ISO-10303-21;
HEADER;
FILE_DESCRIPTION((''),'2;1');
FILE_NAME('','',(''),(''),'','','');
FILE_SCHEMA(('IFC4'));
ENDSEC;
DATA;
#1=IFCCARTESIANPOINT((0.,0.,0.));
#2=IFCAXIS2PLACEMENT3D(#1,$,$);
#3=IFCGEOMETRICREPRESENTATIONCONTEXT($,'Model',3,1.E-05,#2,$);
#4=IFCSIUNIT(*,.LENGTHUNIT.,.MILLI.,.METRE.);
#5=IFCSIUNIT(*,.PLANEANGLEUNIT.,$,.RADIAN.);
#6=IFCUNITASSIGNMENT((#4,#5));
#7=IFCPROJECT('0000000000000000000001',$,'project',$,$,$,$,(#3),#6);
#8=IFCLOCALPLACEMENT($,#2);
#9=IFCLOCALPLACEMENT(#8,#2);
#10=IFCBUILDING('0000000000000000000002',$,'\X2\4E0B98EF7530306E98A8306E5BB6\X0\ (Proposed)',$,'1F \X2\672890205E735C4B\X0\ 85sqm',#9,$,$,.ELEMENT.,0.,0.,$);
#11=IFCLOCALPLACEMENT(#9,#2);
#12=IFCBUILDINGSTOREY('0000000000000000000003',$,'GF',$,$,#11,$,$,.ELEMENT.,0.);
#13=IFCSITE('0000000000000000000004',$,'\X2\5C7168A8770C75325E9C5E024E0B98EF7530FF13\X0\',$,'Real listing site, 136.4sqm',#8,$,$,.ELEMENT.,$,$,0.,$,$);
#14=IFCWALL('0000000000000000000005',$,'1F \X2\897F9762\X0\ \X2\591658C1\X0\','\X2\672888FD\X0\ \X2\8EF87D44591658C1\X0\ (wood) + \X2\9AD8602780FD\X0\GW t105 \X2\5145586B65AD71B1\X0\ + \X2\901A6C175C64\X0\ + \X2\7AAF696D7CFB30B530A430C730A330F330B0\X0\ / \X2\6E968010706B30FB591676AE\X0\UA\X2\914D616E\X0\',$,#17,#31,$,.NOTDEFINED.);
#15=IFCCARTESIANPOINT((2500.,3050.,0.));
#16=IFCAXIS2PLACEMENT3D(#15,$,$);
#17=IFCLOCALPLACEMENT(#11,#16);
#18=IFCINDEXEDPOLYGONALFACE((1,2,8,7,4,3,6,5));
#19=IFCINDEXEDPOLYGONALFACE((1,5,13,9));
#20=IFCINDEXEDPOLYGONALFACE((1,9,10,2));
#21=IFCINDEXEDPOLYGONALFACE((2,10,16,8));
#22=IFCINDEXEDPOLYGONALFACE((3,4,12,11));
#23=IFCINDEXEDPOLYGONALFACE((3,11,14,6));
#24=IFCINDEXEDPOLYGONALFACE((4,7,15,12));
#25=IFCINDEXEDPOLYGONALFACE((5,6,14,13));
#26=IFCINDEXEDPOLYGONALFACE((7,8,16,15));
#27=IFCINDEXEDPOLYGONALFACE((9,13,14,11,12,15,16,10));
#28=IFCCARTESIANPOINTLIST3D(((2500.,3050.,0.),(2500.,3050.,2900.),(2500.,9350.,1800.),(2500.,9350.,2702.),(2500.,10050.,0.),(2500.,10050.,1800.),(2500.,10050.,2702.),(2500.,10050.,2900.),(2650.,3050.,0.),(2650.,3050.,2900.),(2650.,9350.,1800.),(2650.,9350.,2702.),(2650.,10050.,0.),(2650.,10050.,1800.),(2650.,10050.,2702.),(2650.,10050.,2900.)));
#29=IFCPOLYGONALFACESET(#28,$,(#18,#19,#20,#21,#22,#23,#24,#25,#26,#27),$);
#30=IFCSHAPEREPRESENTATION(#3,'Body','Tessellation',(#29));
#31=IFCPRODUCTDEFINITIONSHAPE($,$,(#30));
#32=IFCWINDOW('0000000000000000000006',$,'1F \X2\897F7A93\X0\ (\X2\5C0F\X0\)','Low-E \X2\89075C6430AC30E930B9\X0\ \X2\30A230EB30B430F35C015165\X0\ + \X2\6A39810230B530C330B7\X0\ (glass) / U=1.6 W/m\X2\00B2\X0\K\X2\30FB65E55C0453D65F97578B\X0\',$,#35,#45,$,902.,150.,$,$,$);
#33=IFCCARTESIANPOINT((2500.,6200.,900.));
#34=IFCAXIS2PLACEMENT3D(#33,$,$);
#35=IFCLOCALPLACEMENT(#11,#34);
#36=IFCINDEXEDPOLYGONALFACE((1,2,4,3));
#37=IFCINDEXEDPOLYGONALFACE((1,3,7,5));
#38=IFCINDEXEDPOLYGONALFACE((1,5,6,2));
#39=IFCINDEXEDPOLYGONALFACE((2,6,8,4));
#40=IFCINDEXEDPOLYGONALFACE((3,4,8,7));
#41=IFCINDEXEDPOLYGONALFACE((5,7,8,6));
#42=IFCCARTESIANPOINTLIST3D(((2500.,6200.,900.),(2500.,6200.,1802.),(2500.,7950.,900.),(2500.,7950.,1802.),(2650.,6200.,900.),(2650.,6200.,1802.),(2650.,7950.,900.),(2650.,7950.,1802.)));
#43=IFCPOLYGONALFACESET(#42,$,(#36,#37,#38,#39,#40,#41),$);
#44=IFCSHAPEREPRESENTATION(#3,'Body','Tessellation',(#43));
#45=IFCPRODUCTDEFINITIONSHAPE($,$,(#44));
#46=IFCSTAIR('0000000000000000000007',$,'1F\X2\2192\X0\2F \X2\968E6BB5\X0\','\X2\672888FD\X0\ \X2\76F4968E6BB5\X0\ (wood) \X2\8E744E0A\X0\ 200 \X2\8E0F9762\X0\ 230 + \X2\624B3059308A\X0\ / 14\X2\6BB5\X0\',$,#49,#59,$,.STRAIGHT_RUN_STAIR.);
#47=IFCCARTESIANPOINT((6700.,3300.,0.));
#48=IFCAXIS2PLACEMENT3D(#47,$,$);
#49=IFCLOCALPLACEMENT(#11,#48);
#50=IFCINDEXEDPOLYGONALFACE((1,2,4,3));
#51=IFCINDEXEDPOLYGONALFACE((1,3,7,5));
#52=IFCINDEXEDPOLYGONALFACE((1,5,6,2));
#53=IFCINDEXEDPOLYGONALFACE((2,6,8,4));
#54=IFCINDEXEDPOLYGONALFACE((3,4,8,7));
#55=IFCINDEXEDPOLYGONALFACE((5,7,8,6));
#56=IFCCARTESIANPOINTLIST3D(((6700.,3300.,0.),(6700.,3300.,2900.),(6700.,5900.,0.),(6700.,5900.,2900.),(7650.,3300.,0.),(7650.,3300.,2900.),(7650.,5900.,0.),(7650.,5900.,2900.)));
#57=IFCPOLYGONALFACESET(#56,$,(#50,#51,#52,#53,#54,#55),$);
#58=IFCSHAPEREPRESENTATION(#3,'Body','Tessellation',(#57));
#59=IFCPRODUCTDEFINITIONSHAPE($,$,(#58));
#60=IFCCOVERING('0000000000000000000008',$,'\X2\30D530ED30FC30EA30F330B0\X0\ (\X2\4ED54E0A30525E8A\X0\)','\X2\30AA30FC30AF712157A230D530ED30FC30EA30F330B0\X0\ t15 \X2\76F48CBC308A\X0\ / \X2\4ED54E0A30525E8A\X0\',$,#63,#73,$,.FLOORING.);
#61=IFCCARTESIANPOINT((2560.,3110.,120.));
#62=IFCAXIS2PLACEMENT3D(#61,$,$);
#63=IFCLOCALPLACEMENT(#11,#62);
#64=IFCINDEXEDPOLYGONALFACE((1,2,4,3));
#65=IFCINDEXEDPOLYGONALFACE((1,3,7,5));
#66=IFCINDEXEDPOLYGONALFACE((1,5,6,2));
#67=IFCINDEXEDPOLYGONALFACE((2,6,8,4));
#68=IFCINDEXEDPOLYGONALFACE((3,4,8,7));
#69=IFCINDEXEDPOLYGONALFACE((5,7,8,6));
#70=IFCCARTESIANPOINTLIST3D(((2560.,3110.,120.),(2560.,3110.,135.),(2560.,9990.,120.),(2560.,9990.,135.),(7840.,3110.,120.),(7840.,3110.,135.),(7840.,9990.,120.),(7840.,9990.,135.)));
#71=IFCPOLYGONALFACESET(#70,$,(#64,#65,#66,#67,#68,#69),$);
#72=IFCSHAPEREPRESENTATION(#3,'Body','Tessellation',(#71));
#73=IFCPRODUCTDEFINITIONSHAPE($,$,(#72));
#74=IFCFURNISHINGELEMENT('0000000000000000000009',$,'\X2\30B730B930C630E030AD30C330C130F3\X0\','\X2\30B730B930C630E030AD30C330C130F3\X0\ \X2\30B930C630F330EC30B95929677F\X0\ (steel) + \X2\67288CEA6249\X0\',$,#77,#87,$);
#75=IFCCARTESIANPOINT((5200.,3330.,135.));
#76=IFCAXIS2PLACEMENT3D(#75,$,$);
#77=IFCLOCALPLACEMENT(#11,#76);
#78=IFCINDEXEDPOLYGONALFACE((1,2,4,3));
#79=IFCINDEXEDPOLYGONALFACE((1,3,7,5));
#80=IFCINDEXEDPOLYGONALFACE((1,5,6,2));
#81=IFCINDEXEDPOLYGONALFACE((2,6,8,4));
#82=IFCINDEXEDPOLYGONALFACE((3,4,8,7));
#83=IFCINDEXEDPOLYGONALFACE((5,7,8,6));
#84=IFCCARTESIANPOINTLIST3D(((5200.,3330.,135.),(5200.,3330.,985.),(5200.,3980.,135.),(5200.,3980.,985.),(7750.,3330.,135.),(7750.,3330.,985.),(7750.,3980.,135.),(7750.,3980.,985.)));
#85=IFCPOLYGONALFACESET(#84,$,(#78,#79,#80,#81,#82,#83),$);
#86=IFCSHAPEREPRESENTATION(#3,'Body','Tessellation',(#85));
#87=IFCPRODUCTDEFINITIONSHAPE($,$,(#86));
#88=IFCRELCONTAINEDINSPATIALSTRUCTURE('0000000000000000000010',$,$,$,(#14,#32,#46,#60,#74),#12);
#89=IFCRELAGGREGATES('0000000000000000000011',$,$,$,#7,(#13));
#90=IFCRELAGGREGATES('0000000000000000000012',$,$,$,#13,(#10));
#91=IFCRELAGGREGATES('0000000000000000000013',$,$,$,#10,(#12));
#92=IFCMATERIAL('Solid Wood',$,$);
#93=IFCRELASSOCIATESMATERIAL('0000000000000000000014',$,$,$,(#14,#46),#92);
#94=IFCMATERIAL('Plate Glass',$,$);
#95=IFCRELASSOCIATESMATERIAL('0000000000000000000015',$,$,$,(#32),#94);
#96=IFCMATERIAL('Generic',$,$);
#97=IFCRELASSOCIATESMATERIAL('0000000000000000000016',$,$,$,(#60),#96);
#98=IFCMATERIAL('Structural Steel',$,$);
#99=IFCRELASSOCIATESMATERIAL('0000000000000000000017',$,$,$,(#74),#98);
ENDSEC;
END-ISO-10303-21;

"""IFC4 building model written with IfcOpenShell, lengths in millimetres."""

from ifc_helpers import new_model, si_unit, frame, frame_2d, origin, place, context, project, spatial, rectangle, extrude, material, element, fill, save


model = new_model("IFC4")

# Units and contexts
model_context = context("Model", 3, precision=1e-05, world=origin())
ifc_project = project(units=[si_unit("LENGTHUNIT", "METRE", prefix="MILLI"), si_unit("PLANEANGLEUNIT", "RADIAN")], contexts=[model_context])

# Site, building, storey
site_placement = place(None, origin())
site = spatial("IfcSite", under=ifc_project, at=site_placement, Name="山梨県甲府市下飯田３", ObjectType="Real listing site, 136.4sqm", CompositionType="ELEMENT", RefElevation=0.0)
building_placement = place(site_placement, origin())
building = spatial("IfcBuilding", under=site, at=building_placement, Name="下飯田の風の家 (Proposed)", ObjectType="1F 木造平屋 85sqm", CompositionType="ELEMENT", ElevationOfRefHeight=0.0, ElevationOfTerrain=0.0)
storey_placement = place(building_placement, origin())
storey = spatial("IfcBuildingStorey", under=building, at=storey_placement, Name="GF", CompositionType="ELEMENT", Elevation=0.0)

# Shared definitions
ifc_material_1 = material(Name="Solid Wood")
ifc_material_2 = material(Name="Generic")

# Shared definitions
ifc_material_3 = material(Name="Plate Glass")

# Wall, opening, window
wall_1_placement = place(storey_placement, frame((2500.0, 3050.0, 0.0)))
wall_1 = element("IfcWall", 1, at=wall_1_placement, inside=storey, material=ifc_material_1, Name="1F 西面 外壁", Description="木製 軸組外壁 (wood) + 高性能GW t105 充填断熱 + 通気層 + 窯業系サイディング / 準耐火・外皮UA配慮", PredefinedType="NOTDEFINED", context=model_context, shape_type="SweptSolid", body=[
    extrude(rectangle(XDim=150.0, YDim=7000.0, at=frame_2d((75.0, 3500.0))), frame((2500.0, 3050.0, 0.0)), (0.0, 0.0, 1.0), 2900.0),
])
opening_1_placement = place(storey_placement, frame((2500.0, 6200.0, 900.0)))
opening_1 = element("IfcOpeningElement", 2, at=opening_1_placement, cuts=wall_1, PredefinedType="NOTDEFINED", context=model_context, shape_type="SweptSolid", body=[
    extrude(rectangle(XDim=150.0, YDim=1750.0, at=frame_2d((75.0, 875.0))), frame((2500.0, 6200.0, 900.0)), (0.0, 0.0, 1.0), 902.0),
])
window_1_placement = place(storey_placement, frame((2500.0, 6200.0, 900.0)))
window_1 = element("IfcWindow", 3, at=window_1_placement, inside=storey, material=ifc_material_3, Name="1F 西窓 (小)", Description="Low-E 複層ガラス アルゴン封入 + 樹脂サッシ (glass) / U=1.6 W/m²K・日射取得型", OverallHeight=902.0, OverallWidth=150.0, context=model_context, shape_type="SweptSolid", body=[
    extrude(rectangle(XDim=150.0, YDim=1750.0, at=frame_2d((75.0, 875.0))), frame((2500.0, 6200.0, 900.0)), (0.0, 0.0, 1.0), 902.0),
])
fill(opening_1, window_1)

# Stair
stair_placement = place(storey_placement, frame((6700.0, 3300.0, 0.0)))
element("IfcStair", 4, at=stair_placement, inside=storey, material=ifc_material_1, Name="1F→2F 階段", Description="木製 直階段 (wood) 蹴上 200 踏面 230 + 手すり / 14段", PredefinedType="STRAIGHT_RUN_STAIR", context=model_context, shape_type="SweptSolid", body=[
    extrude(rectangle(XDim=950.0, YDim=2600.0, at=frame_2d((475.0, 1300.0))), frame((6700.0, 3300.0, 0.0)), (0.0, 0.0, 1.0), 2900.0),
])

# Covering
covering_placement = place(storey_placement, frame((2560.0, 3110.0, 120.0)))
element("IfcCovering", 5, at=covering_placement, inside=storey, material=ifc_material_2, Name="フローリング (仕上げ床)", Description="オーク無垢フローリング t15 直貼り / 仕上げ床", PredefinedType="FLOORING", context=model_context, shape_type="SweptSolid", body=[
    extrude(rectangle(XDim=5280.0, YDim=6880.0, at=frame_2d((2640.0, 3440.0))), frame((2560.0, 3110.0, 120.0)), (0.0, 0.0, 1.0), 15.0),
])

# Furnishing element
ifc_material_4 = material(Name="Structural Steel")
furnishing_placement = place(storey_placement, frame((5200.0, 3330.0, 135.0)))
element("IfcFurnishingElement", 6, at=furnishing_placement, inside=storey, material=ifc_material_4, Name="システムキッチン", Description="システムキッチン ステンレス天板 (steel) + 木質扉", context=model_context, shape_type="SweptSolid", body=[
    extrude(rectangle(XDim=2550.0, YDim=650.0, at=frame_2d((1275.0, 325.0))), frame((5200.0, 3330.0, 135.0)), (0.0, 0.0, 1.0), 850.0),
])

save(model, "model.ifc")
